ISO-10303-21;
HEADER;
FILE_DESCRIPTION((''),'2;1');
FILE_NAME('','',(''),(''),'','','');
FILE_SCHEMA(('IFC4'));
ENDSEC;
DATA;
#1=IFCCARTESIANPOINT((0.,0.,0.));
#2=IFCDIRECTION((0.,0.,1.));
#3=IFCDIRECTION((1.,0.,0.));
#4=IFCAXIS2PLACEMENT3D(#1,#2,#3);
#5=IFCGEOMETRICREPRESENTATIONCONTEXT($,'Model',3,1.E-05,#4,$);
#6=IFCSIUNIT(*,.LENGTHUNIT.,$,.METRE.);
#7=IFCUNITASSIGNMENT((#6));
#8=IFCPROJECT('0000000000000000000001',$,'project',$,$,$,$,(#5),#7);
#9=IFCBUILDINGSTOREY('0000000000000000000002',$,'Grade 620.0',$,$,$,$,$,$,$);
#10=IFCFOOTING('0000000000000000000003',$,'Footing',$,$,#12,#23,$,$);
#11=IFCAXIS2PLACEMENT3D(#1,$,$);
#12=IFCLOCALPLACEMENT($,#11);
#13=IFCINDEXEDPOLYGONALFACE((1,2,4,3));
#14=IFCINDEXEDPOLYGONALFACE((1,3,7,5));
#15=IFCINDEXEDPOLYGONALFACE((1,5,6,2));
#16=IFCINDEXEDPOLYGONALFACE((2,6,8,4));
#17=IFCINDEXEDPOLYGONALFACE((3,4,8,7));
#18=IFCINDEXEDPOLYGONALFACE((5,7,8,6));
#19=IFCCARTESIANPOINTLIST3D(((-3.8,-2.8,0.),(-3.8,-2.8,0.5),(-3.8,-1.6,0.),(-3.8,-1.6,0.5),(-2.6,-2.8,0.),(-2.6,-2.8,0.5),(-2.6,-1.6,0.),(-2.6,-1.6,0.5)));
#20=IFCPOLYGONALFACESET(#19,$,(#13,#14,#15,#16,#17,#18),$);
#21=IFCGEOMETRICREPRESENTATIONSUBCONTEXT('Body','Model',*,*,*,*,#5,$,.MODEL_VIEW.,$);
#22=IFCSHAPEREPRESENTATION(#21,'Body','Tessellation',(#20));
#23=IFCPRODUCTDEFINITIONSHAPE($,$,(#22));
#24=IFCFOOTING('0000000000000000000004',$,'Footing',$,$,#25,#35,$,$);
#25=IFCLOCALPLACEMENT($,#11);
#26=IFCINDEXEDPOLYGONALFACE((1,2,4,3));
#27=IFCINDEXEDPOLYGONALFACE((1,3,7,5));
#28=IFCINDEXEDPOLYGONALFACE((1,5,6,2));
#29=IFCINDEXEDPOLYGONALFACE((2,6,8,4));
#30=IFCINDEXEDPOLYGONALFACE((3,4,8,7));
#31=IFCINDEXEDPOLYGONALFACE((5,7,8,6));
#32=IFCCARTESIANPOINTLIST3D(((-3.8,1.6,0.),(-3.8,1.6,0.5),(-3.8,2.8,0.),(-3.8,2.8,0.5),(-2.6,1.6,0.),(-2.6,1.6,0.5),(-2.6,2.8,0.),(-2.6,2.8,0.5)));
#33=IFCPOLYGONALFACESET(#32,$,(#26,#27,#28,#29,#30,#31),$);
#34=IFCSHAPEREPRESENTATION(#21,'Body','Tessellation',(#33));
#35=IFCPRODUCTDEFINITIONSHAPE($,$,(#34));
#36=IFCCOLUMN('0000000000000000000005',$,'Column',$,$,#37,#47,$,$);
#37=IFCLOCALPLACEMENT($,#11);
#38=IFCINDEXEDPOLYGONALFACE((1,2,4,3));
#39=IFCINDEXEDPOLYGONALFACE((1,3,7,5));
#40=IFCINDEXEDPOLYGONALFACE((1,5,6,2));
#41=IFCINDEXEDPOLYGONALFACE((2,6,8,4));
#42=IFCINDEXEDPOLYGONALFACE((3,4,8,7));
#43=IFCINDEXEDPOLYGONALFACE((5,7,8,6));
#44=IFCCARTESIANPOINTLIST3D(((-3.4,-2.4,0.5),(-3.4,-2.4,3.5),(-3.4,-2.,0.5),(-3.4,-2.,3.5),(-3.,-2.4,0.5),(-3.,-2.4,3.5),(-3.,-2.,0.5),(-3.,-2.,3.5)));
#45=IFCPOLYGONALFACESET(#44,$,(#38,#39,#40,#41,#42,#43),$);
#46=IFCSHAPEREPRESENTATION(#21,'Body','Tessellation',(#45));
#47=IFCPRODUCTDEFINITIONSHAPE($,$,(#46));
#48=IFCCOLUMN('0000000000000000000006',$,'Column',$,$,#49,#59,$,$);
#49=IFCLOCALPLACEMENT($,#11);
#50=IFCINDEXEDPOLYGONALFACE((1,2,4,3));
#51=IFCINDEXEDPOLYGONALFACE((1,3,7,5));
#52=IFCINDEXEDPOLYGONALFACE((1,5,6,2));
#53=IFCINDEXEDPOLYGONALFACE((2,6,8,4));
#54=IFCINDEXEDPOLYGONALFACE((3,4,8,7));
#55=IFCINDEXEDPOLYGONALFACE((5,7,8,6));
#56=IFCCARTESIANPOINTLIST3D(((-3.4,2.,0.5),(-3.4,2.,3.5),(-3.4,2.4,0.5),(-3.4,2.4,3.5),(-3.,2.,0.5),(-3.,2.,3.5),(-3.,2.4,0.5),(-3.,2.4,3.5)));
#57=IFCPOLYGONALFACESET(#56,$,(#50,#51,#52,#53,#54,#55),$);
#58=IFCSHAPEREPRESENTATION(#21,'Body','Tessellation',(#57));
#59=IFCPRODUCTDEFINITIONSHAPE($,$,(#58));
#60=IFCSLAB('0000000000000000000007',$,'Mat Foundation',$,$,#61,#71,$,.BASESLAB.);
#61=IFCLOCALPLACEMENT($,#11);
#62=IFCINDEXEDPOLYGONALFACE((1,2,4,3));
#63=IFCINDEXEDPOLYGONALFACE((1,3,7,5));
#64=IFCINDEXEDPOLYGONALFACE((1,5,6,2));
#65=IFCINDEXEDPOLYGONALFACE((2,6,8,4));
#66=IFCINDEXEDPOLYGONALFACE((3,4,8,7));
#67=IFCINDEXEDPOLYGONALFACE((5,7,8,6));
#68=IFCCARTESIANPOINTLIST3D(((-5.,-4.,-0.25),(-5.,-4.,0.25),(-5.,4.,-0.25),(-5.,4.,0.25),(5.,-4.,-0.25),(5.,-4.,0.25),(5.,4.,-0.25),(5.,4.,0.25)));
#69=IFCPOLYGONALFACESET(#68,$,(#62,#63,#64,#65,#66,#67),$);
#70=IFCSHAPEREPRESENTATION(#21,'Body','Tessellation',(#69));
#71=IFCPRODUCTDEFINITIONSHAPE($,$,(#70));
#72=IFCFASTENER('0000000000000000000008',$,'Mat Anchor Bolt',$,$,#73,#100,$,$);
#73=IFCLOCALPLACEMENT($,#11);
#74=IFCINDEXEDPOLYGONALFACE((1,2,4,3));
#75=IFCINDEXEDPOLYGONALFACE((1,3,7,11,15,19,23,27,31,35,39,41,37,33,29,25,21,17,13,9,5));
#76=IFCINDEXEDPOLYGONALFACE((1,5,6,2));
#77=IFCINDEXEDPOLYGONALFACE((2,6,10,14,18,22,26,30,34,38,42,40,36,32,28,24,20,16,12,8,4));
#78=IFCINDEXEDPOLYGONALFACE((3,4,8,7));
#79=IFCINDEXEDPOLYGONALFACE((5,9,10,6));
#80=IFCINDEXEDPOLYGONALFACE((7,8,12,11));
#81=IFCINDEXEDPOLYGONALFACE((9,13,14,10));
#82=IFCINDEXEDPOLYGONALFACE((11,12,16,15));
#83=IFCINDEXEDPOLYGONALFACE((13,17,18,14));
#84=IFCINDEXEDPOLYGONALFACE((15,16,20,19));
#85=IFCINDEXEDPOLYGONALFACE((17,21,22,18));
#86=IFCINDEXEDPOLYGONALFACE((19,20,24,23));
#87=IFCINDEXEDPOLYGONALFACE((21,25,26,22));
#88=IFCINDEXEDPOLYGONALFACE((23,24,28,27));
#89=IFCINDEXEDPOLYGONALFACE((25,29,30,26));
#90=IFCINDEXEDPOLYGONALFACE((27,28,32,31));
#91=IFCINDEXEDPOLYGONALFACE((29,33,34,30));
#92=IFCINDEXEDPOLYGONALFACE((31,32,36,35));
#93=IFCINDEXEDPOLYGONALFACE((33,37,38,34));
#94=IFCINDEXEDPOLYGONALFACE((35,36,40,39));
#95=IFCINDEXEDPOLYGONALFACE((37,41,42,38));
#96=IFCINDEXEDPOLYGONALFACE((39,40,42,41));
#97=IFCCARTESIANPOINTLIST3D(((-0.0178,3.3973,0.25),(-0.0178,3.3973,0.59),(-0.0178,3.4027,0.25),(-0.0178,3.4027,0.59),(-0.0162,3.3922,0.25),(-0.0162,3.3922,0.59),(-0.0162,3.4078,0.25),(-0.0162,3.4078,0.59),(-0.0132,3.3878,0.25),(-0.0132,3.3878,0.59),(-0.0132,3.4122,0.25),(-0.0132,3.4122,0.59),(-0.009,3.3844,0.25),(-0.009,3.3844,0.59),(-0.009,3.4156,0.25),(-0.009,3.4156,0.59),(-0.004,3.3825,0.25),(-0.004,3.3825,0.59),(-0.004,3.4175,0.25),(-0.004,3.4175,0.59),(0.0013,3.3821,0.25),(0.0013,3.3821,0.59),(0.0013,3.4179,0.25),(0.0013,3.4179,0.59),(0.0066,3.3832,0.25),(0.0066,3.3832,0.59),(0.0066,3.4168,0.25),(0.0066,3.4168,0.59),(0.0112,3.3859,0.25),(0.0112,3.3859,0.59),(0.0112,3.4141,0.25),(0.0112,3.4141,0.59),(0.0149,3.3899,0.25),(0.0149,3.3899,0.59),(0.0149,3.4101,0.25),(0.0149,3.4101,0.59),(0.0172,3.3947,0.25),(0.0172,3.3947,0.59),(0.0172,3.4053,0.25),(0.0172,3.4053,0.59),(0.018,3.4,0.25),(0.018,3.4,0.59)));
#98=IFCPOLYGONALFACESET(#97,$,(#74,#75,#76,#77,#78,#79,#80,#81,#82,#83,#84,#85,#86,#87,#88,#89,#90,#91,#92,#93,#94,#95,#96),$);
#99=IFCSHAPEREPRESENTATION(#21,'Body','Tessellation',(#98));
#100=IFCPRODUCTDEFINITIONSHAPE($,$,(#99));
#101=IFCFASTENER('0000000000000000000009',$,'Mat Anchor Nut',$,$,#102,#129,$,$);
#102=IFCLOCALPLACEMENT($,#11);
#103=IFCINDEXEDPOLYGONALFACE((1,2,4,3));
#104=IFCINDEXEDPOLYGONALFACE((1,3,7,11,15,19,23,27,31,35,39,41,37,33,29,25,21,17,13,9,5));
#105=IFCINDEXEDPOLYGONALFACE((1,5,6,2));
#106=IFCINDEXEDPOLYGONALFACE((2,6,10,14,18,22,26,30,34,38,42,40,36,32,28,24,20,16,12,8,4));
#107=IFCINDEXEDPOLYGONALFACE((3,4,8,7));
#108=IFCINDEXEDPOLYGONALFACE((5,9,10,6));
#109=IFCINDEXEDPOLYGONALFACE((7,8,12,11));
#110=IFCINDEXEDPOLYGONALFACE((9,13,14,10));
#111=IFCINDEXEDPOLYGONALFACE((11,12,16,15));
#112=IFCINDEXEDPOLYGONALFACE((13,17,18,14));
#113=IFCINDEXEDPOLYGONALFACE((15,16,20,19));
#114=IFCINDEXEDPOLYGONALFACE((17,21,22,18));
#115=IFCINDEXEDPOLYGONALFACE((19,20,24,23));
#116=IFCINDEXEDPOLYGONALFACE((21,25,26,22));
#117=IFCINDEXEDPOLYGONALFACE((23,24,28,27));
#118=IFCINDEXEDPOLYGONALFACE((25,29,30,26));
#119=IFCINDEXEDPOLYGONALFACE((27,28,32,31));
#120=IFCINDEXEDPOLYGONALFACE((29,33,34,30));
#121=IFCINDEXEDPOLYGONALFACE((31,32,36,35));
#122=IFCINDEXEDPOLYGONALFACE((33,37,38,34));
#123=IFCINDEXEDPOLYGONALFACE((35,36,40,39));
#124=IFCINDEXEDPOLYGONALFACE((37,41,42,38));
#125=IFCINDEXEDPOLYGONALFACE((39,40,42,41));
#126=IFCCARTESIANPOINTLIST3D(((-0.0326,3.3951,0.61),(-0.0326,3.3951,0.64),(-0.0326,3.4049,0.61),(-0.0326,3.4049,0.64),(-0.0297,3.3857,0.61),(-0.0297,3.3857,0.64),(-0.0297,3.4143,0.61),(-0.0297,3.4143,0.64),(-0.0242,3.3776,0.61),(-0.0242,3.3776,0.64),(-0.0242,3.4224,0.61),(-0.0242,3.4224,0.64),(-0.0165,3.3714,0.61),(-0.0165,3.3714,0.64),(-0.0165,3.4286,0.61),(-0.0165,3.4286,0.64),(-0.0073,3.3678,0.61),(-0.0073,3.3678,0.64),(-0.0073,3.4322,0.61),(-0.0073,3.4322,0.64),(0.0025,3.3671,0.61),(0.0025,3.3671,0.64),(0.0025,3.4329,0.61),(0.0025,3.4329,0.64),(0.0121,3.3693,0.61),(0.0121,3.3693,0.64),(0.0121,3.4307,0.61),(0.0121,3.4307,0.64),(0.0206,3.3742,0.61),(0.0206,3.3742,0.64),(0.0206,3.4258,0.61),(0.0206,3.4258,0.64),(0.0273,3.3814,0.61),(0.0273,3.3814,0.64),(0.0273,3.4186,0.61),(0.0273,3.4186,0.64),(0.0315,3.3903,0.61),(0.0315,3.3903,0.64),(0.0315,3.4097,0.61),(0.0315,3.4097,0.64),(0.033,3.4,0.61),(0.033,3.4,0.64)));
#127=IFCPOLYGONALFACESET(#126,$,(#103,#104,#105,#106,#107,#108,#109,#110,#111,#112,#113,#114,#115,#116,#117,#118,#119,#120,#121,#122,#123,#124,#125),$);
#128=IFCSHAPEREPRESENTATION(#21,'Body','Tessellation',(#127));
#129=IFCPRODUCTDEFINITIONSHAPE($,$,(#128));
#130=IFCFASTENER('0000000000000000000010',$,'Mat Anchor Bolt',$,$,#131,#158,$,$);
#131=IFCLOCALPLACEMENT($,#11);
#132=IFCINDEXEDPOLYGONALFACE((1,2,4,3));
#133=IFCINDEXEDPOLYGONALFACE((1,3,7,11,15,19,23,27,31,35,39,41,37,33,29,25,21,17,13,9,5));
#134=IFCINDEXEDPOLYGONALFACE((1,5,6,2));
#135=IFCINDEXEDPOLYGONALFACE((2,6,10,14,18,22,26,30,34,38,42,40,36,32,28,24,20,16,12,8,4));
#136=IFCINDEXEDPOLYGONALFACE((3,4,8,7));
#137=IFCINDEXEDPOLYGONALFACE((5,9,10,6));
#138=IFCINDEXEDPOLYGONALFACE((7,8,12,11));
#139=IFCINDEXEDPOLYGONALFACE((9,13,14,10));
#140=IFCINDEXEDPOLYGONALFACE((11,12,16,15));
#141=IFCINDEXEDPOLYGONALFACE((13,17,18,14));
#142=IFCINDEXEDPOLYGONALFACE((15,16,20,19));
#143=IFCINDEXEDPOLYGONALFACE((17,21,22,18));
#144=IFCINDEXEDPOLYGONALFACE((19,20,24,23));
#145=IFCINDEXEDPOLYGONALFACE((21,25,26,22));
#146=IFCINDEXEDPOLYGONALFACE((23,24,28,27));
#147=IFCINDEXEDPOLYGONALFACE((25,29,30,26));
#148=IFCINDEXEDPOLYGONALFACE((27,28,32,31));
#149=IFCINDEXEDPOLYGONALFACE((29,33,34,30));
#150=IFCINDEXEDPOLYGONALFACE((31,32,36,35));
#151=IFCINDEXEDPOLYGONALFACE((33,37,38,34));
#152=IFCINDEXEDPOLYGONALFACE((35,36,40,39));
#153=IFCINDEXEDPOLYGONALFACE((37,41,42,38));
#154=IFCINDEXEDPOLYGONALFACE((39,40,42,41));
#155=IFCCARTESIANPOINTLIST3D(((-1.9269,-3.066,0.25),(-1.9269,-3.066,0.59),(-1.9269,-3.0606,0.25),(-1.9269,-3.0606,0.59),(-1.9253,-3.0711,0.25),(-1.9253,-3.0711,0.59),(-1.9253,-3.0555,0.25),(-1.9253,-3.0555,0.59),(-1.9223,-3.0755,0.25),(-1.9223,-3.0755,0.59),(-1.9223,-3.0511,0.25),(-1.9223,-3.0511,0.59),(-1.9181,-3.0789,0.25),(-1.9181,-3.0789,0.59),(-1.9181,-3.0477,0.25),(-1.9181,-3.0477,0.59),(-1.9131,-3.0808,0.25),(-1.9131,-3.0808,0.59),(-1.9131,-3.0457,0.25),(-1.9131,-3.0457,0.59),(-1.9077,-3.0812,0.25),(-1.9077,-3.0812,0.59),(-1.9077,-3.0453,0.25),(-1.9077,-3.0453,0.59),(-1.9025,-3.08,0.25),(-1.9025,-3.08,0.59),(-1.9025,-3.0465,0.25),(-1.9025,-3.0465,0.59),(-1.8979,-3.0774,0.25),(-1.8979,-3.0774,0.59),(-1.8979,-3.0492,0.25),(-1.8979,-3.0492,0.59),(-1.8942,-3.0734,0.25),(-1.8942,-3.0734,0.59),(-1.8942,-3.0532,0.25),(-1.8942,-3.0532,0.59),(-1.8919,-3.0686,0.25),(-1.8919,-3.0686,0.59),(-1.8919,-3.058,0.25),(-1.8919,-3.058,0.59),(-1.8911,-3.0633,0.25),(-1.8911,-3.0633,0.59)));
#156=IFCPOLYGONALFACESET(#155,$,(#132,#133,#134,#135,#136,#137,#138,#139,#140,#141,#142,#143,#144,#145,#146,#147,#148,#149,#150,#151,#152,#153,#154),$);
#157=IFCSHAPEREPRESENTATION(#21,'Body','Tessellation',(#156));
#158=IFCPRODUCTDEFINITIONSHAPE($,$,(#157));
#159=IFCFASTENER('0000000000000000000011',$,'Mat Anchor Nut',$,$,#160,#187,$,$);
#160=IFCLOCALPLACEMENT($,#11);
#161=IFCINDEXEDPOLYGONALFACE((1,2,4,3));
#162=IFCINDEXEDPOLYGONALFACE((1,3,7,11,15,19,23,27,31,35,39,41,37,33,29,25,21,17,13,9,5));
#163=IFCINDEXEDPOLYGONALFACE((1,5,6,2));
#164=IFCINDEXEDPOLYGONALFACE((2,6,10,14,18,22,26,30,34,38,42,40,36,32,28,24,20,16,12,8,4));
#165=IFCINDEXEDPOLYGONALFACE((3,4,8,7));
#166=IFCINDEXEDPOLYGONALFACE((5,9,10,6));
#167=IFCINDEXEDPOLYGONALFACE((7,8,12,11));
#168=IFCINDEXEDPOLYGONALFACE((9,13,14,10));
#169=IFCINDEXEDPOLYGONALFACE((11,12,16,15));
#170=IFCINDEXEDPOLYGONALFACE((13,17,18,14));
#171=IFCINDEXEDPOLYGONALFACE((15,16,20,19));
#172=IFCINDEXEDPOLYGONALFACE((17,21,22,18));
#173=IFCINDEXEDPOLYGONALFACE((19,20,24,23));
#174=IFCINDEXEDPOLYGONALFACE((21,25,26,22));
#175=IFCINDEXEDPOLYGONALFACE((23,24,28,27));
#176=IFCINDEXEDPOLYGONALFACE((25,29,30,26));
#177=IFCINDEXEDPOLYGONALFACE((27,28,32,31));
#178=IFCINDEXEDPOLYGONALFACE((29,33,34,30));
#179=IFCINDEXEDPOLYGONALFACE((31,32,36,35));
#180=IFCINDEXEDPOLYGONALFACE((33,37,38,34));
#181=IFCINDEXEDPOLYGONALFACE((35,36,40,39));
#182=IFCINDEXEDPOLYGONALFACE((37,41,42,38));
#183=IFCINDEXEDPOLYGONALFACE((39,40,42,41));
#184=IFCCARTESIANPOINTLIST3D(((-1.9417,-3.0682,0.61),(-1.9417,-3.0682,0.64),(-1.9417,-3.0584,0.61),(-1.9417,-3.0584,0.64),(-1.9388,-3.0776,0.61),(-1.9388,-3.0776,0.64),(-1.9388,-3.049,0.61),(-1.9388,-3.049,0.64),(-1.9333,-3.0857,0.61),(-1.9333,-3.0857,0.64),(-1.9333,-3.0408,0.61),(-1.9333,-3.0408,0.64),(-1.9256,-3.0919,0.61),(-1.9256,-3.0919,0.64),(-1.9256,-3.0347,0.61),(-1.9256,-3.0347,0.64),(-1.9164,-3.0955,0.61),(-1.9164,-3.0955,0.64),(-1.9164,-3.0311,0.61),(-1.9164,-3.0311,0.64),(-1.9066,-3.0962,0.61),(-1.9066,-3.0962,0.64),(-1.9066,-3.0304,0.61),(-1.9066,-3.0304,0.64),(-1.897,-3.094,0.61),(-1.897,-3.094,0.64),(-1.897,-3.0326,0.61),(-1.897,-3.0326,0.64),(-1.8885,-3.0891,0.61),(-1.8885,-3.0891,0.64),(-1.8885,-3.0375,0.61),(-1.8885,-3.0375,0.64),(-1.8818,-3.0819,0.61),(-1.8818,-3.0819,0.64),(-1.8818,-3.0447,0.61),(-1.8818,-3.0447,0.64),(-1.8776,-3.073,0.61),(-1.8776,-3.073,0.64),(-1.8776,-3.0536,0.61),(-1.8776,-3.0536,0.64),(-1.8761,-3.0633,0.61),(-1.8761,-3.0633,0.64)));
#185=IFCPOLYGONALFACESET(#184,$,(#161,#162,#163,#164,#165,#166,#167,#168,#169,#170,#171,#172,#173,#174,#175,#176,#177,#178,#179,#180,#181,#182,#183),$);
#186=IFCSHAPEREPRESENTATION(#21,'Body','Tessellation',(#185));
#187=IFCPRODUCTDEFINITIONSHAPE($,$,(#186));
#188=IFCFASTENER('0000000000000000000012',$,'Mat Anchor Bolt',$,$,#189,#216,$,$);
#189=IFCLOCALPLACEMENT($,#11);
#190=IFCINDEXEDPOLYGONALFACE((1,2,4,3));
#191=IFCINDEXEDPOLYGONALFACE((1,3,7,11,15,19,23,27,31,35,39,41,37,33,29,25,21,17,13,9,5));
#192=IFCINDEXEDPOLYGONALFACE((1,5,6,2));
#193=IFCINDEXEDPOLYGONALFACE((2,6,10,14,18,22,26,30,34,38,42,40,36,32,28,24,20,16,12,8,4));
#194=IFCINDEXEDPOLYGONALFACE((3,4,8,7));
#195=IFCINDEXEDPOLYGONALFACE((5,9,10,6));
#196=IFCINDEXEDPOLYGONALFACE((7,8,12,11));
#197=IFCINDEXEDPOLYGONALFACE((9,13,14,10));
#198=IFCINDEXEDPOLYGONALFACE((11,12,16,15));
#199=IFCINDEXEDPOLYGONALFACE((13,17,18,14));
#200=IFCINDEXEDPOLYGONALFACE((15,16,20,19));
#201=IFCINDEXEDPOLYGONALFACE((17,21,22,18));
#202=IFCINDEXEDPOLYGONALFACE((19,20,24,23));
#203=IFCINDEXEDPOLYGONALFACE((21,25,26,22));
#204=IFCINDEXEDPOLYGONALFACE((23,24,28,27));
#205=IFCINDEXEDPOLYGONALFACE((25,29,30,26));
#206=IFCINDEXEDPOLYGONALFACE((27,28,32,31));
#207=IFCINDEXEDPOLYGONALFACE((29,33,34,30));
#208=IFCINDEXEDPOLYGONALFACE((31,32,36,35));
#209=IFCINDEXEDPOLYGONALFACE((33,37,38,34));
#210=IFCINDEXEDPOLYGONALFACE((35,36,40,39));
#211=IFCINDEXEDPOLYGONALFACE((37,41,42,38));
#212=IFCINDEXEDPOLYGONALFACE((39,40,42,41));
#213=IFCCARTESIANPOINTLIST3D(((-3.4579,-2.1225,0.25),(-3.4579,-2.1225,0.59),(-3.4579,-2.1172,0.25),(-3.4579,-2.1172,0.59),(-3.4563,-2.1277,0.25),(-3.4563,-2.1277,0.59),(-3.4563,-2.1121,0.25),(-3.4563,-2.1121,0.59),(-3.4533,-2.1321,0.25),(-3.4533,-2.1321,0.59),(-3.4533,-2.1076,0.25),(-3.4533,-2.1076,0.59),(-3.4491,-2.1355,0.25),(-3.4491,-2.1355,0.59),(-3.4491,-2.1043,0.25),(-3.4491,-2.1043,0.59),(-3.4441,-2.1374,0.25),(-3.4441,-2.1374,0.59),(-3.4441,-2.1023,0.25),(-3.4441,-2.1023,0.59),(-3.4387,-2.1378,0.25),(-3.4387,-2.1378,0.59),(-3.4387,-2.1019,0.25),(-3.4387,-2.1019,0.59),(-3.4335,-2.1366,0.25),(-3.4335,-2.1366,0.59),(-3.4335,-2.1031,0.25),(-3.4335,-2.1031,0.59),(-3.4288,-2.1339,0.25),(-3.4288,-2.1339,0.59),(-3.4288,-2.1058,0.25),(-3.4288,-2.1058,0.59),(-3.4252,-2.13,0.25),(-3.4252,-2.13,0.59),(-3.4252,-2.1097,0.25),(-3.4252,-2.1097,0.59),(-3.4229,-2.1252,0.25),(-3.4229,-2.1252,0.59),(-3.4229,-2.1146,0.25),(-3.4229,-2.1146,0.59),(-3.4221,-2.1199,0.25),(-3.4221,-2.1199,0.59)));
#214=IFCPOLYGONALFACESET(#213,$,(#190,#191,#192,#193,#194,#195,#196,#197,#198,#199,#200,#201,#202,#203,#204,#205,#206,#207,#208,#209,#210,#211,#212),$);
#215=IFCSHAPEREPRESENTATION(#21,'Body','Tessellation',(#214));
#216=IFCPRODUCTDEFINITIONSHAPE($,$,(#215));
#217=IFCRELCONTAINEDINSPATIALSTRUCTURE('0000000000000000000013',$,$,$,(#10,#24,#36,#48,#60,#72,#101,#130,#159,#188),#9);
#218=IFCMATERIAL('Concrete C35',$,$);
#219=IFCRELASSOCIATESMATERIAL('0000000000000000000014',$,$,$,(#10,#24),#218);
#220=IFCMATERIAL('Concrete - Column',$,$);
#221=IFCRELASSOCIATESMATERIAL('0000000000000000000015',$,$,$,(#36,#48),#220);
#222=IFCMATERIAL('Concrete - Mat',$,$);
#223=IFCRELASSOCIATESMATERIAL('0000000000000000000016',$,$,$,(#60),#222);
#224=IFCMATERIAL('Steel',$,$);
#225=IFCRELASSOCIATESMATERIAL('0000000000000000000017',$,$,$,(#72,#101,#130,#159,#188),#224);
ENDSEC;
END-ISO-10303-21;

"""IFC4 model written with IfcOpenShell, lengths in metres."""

from ifc_helpers import new_model, si_unit, frame, origin_with_axes, place, context, subcontext, project, spatial, indexed_curve, rectangle, circle, outline, extrude, material, element, save


model = new_model("IFC4")

# Units and contexts
model_context = context("Model", 3, precision=1e-05, world=origin_with_axes())
body_context = subcontext(model_context, "Body", "Model", "MODEL_VIEW")
ifc_project = project(units=[si_unit("LENGTHUNIT", "METRE")], contexts=[model_context])

# Storey
storey = spatial("IfcBuildingStorey", Name="Grade 620.0")

# Footings
ifc_material_1 = material(Name="Concrete C35")
for number, where, z_axis, x_axis, name in (
    (1, (-3.2, -2.2, 0.0), (0.0, 0.0, 1.0), (1.0, 0.0, 0.0), "Footing"),
    (2, (-3.2, 2.2, 0.0), (0.0, 0.0, 1.0), (1.0, 0.0, 0.0), "Footing"),
):
    element("IfcFooting", number, at=place(None, frame(where, z_axis=z_axis, x_axis=x_axis)), inside=storey, material=ifc_material_1, Name=name, context=body_context, shape_type="SweptSolid", body=[
        extrude(rectangle(XDim=1.2, YDim=1.2), origin_with_axes(), (0.0, 0.0, 1.0), 0.5),
    ])

# Columns
ifc_material_2 = material(Name="Concrete - Column")
for number, where, z_axis, x_axis, name in (
    (3, (-3.2, -2.2, 0.5), (0.0, 0.0, 1.0), (1.0, 0.0, 0.0), "Column"),
    (4, (-3.2, 2.2, 0.5), (0.0, 0.0, 1.0), (1.0, 0.0, 0.0), "Column"),
):
    element("IfcColumn", number, at=place(None, frame(where, z_axis=z_axis, x_axis=x_axis)), inside=storey, material=ifc_material_2, Name=name, context=body_context, shape_type="SweptSolid", body=[
        extrude(rectangle(XDim=0.4, YDim=0.4), origin_with_axes(), (0.0, 0.0, 1.0), 3.0),
    ])

# Slab
ifc_material_3 = material(Name="Concrete - Mat")
slab_placement = place(None, frame((0.0, 0.0, -0.25), z_axis=(0.0, 0.0, 1.0), x_axis=(1.0, 0.0, 0.0)))
element("IfcSlab", 5, at=slab_placement, inside=storey, material=ifc_material_3, Name="Mat Foundation", PredefinedType="BASESLAB", context=body_context, shape_type="SweptSolid", body=[
    extrude(outline(indexed_curve([(-5.0, -4.0), (5.0, -4.0), (5.0, 4.0), (-5.0, 4.0)])), None, (0.0, 0.0, 1.0), 0.5),
])

# Fasteners
ifc_material_4 = material(Name="Steel")
fastener_1_placement = place(None, frame((0.0, 3.4, 0.25), z_axis=(0.0, 0.0, 1.0), x_axis=(1.0, 0.0, 0.0)))
element("IfcFastener", 6, at=fastener_1_placement, inside=storey, material=ifc_material_4, Name="Mat Anchor Bolt", context=body_context, shape_type="SweptSolid", body=[
    extrude(circle(Radius=0.018), origin_with_axes(), (0.0, 0.0, 1.0), 0.34),
])
fastener_2_placement = place(None, frame((0.0, 3.4, 0.61), z_axis=(0.0, 0.0, 1.0), x_axis=(1.0, 0.0, 0.0)))
element("IfcFastener", 7, at=fastener_2_placement, inside=storey, material=ifc_material_4, Name="Mat Anchor Nut", context=body_context, shape_type="SweptSolid", body=[
    extrude(circle(Radius=0.033), origin_with_axes(), (0.0, 0.0, 1.0), 0.03),
])
fastener_3_placement = place(None, frame((-1.9091, -3.0633, 0.25), z_axis=(0.0, 0.0, 1.0), x_axis=(1.0, 0.0, 0.0)))
element("IfcFastener", 8, at=fastener_3_placement, inside=storey, material=ifc_material_4, Name="Mat Anchor Bolt", context=body_context, shape_type="SweptSolid", body=[
    extrude(circle(Radius=0.018), origin_with_axes(), (0.0, 0.0, 1.0), 0.34),
])
fastener_4_placement = place(None, frame((-1.9091, -3.0633, 0.61), z_axis=(0.0, 0.0, 1.0), x_axis=(1.0, 0.0, 0.0)))
element("IfcFastener", 9, at=fastener_4_placement, inside=storey, material=ifc_material_4, Name="Mat Anchor Nut", context=body_context, shape_type="SweptSolid", body=[
    extrude(circle(Radius=0.033), origin_with_axes(), (0.0, 0.0, 1.0), 0.03),
])
fastener_5_placement = place(None, frame((-3.4401, -2.1199, 0.25), z_axis=(0.0, 0.0, 1.0), x_axis=(1.0, 0.0, 0.0)))
element("IfcFastener", 10, at=fastener_5_placement, inside=storey, material=ifc_material_4, Name="Mat Anchor Bolt", context=body_context, shape_type="SweptSolid", body=[
    extrude(circle(Radius=0.018), origin_with_axes(), (0.0, 0.0, 1.0), 0.34),
])

save(model, "model.ifc")
